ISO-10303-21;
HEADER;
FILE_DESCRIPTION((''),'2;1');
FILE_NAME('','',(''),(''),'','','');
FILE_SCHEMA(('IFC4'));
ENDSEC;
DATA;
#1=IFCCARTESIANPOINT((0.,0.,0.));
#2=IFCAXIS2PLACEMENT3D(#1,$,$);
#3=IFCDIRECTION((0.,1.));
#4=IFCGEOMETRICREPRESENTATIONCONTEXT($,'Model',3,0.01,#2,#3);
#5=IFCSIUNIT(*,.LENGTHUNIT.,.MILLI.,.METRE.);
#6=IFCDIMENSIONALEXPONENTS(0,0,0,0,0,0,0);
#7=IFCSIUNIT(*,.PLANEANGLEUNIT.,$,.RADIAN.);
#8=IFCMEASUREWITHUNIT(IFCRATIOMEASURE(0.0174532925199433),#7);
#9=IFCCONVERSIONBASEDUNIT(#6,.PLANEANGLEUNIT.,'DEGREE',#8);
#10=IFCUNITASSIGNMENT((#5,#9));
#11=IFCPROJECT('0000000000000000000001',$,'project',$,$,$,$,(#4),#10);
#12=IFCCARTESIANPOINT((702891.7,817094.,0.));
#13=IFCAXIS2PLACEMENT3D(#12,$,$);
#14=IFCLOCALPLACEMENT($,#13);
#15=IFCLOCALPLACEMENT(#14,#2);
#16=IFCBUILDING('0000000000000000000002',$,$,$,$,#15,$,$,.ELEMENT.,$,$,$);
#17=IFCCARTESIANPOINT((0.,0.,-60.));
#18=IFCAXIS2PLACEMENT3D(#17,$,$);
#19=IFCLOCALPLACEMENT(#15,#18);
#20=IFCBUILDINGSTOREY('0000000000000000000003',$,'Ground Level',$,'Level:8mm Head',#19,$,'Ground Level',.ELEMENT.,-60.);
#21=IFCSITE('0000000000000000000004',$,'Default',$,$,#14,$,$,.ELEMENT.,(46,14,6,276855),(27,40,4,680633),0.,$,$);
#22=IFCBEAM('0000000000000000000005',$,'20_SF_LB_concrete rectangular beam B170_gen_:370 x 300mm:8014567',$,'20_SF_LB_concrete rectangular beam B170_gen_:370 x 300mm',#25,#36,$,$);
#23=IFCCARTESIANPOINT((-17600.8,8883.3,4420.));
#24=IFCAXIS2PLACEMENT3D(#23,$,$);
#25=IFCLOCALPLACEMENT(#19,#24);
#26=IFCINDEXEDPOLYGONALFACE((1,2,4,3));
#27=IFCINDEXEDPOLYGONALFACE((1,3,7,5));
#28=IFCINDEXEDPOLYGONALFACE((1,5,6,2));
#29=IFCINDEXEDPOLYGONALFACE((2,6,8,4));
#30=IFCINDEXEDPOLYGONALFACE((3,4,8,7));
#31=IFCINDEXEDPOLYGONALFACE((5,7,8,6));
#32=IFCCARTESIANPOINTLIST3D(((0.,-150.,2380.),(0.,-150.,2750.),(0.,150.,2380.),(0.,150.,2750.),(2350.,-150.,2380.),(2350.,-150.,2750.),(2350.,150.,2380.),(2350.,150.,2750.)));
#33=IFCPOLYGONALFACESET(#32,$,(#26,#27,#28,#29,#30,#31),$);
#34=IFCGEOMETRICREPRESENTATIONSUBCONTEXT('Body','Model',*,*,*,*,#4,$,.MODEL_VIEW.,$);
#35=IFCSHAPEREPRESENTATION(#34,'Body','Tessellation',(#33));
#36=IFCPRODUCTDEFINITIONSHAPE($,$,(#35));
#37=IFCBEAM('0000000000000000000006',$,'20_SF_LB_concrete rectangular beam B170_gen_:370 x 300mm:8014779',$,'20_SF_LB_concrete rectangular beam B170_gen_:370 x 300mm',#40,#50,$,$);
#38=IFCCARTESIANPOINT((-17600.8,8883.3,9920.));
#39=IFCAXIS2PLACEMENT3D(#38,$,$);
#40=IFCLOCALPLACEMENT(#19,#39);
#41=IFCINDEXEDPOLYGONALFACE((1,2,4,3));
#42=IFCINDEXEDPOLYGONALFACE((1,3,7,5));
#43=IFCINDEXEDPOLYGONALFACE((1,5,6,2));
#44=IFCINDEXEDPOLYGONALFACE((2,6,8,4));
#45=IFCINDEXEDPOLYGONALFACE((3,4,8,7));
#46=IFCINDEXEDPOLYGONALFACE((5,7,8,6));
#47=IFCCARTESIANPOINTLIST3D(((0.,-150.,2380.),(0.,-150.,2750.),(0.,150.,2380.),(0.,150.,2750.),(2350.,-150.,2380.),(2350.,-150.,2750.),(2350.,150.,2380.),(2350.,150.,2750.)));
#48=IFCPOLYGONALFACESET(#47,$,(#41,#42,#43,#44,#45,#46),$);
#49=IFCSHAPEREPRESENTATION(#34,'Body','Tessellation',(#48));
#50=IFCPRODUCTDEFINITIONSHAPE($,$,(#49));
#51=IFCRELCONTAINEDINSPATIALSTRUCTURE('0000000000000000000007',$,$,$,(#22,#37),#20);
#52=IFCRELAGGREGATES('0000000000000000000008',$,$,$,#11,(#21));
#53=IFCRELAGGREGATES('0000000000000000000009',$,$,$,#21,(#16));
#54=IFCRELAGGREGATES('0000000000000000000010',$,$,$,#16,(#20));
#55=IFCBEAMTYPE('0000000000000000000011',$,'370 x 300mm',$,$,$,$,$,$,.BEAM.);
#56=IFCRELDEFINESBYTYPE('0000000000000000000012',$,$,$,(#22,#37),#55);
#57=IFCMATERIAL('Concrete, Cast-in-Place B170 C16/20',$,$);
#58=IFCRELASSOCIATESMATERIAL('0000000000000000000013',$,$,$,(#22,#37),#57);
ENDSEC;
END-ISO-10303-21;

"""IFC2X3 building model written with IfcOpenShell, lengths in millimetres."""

from ifc_helpers import new_model, entity, si_unit, converted_unit, direction, frame, frame_2d, origin, place, context, subcontext, project, spatial, rectangle, extrude, material, type_object, element, save


model = new_model("IFC2X3")

# Units and contexts
model_context = context("Model", 3, precision=0.01, world=origin(), true_north=direction((0.0, 1.0)))
body_context = subcontext(model_context, "Body", "Model", "MODEL_VIEW")
ifc_project = project(units=[si_unit("LENGTHUNIT", "METRE", prefix="MILLI"), converted_unit("PLANEANGLEUNIT", "DEGREE", entity("IfcRatioMeasure", 0.0174532925199433), si_unit("PLANEANGLEUNIT", "RADIAN"), dimensions=[0, 0, 0, 0, 0, 0, 0])], contexts=[model_context])

# Site, building, storey
site_placement = place(None, frame((702891.7, 817094.0, 0.0)))
site = spatial("IfcSite", under=ifc_project, at=site_placement, Name="Default", CompositionType="ELEMENT", RefLatitude=(46, 14, 6, 276855), RefLongitude=(27, 40, 4, 680633), RefElevation=0.0)
building_placement = place(site_placement, origin())
building = spatial("IfcBuilding", under=site, at=building_placement, CompositionType="ELEMENT")
storey_placement = place(building_placement, frame((0.0, 0.0, -60.0)))
storey = spatial("IfcBuildingStorey", under=building, at=storey_placement, Name="Ground Level", ObjectType="Level:8mm Head", LongName="Ground Level", CompositionType="ELEMENT", Elevation=-60.0)

# Beams
ifc_material_1 = material(Name="Concrete, Cast-in-Place B170 C16/20")
beam_type = type_object("IfcBeamType", Name="370 x 300mm", PredefinedType="BEAM")
beam_1_placement = place(storey_placement, frame((-17600.8, 8883.3, 4420.0)))
element("IfcBeam", 1, at=beam_1_placement, inside=storey, type_object=beam_type, material=ifc_material_1, Name="20_SF_LB_concrete rectangular beam B170_gen_:370 x 300mm:8014567", ObjectType="20_SF_LB_concrete rectangular beam B170_gen_:370 x 300mm", context=body_context, shape_type="SweptSolid", body=[
    extrude(rectangle(XDim=370.0, YDim=300.0, at=frame_2d((0.0, 0.0), x_axis=(1.0, 0.0))), frame((0.0, 0.0, 2565.0), z_axis=(1.0, 0.0, 0.0), x_axis=(0.0, 0.0, -1.0)), (0.0, 0.0, 1.0), 2350.0),
])
beam_2_placement = place(storey_placement, frame((-17600.8, 8883.3, 9920.0)))
element("IfcBeam", 2, at=beam_2_placement, inside=storey, type_object=beam_type, material=ifc_material_1, Name="20_SF_LB_concrete rectangular beam B170_gen_:370 x 300mm:8014779", ObjectType="20_SF_LB_concrete rectangular beam B170_gen_:370 x 300mm", context=body_context, shape_type="SweptSolid", body=[
    extrude(rectangle(XDim=370.0, YDim=300.0, at=frame_2d((0.0, 0.0), x_axis=(1.0, 0.0))), frame((0.0, 0.0, 2565.0), z_axis=(1.0, 0.0, 0.0), x_axis=(0.0, 0.0, -1.0)), (0.0, 0.0, 1.0), 2350.0),
])

save(model, "model.ifc")
